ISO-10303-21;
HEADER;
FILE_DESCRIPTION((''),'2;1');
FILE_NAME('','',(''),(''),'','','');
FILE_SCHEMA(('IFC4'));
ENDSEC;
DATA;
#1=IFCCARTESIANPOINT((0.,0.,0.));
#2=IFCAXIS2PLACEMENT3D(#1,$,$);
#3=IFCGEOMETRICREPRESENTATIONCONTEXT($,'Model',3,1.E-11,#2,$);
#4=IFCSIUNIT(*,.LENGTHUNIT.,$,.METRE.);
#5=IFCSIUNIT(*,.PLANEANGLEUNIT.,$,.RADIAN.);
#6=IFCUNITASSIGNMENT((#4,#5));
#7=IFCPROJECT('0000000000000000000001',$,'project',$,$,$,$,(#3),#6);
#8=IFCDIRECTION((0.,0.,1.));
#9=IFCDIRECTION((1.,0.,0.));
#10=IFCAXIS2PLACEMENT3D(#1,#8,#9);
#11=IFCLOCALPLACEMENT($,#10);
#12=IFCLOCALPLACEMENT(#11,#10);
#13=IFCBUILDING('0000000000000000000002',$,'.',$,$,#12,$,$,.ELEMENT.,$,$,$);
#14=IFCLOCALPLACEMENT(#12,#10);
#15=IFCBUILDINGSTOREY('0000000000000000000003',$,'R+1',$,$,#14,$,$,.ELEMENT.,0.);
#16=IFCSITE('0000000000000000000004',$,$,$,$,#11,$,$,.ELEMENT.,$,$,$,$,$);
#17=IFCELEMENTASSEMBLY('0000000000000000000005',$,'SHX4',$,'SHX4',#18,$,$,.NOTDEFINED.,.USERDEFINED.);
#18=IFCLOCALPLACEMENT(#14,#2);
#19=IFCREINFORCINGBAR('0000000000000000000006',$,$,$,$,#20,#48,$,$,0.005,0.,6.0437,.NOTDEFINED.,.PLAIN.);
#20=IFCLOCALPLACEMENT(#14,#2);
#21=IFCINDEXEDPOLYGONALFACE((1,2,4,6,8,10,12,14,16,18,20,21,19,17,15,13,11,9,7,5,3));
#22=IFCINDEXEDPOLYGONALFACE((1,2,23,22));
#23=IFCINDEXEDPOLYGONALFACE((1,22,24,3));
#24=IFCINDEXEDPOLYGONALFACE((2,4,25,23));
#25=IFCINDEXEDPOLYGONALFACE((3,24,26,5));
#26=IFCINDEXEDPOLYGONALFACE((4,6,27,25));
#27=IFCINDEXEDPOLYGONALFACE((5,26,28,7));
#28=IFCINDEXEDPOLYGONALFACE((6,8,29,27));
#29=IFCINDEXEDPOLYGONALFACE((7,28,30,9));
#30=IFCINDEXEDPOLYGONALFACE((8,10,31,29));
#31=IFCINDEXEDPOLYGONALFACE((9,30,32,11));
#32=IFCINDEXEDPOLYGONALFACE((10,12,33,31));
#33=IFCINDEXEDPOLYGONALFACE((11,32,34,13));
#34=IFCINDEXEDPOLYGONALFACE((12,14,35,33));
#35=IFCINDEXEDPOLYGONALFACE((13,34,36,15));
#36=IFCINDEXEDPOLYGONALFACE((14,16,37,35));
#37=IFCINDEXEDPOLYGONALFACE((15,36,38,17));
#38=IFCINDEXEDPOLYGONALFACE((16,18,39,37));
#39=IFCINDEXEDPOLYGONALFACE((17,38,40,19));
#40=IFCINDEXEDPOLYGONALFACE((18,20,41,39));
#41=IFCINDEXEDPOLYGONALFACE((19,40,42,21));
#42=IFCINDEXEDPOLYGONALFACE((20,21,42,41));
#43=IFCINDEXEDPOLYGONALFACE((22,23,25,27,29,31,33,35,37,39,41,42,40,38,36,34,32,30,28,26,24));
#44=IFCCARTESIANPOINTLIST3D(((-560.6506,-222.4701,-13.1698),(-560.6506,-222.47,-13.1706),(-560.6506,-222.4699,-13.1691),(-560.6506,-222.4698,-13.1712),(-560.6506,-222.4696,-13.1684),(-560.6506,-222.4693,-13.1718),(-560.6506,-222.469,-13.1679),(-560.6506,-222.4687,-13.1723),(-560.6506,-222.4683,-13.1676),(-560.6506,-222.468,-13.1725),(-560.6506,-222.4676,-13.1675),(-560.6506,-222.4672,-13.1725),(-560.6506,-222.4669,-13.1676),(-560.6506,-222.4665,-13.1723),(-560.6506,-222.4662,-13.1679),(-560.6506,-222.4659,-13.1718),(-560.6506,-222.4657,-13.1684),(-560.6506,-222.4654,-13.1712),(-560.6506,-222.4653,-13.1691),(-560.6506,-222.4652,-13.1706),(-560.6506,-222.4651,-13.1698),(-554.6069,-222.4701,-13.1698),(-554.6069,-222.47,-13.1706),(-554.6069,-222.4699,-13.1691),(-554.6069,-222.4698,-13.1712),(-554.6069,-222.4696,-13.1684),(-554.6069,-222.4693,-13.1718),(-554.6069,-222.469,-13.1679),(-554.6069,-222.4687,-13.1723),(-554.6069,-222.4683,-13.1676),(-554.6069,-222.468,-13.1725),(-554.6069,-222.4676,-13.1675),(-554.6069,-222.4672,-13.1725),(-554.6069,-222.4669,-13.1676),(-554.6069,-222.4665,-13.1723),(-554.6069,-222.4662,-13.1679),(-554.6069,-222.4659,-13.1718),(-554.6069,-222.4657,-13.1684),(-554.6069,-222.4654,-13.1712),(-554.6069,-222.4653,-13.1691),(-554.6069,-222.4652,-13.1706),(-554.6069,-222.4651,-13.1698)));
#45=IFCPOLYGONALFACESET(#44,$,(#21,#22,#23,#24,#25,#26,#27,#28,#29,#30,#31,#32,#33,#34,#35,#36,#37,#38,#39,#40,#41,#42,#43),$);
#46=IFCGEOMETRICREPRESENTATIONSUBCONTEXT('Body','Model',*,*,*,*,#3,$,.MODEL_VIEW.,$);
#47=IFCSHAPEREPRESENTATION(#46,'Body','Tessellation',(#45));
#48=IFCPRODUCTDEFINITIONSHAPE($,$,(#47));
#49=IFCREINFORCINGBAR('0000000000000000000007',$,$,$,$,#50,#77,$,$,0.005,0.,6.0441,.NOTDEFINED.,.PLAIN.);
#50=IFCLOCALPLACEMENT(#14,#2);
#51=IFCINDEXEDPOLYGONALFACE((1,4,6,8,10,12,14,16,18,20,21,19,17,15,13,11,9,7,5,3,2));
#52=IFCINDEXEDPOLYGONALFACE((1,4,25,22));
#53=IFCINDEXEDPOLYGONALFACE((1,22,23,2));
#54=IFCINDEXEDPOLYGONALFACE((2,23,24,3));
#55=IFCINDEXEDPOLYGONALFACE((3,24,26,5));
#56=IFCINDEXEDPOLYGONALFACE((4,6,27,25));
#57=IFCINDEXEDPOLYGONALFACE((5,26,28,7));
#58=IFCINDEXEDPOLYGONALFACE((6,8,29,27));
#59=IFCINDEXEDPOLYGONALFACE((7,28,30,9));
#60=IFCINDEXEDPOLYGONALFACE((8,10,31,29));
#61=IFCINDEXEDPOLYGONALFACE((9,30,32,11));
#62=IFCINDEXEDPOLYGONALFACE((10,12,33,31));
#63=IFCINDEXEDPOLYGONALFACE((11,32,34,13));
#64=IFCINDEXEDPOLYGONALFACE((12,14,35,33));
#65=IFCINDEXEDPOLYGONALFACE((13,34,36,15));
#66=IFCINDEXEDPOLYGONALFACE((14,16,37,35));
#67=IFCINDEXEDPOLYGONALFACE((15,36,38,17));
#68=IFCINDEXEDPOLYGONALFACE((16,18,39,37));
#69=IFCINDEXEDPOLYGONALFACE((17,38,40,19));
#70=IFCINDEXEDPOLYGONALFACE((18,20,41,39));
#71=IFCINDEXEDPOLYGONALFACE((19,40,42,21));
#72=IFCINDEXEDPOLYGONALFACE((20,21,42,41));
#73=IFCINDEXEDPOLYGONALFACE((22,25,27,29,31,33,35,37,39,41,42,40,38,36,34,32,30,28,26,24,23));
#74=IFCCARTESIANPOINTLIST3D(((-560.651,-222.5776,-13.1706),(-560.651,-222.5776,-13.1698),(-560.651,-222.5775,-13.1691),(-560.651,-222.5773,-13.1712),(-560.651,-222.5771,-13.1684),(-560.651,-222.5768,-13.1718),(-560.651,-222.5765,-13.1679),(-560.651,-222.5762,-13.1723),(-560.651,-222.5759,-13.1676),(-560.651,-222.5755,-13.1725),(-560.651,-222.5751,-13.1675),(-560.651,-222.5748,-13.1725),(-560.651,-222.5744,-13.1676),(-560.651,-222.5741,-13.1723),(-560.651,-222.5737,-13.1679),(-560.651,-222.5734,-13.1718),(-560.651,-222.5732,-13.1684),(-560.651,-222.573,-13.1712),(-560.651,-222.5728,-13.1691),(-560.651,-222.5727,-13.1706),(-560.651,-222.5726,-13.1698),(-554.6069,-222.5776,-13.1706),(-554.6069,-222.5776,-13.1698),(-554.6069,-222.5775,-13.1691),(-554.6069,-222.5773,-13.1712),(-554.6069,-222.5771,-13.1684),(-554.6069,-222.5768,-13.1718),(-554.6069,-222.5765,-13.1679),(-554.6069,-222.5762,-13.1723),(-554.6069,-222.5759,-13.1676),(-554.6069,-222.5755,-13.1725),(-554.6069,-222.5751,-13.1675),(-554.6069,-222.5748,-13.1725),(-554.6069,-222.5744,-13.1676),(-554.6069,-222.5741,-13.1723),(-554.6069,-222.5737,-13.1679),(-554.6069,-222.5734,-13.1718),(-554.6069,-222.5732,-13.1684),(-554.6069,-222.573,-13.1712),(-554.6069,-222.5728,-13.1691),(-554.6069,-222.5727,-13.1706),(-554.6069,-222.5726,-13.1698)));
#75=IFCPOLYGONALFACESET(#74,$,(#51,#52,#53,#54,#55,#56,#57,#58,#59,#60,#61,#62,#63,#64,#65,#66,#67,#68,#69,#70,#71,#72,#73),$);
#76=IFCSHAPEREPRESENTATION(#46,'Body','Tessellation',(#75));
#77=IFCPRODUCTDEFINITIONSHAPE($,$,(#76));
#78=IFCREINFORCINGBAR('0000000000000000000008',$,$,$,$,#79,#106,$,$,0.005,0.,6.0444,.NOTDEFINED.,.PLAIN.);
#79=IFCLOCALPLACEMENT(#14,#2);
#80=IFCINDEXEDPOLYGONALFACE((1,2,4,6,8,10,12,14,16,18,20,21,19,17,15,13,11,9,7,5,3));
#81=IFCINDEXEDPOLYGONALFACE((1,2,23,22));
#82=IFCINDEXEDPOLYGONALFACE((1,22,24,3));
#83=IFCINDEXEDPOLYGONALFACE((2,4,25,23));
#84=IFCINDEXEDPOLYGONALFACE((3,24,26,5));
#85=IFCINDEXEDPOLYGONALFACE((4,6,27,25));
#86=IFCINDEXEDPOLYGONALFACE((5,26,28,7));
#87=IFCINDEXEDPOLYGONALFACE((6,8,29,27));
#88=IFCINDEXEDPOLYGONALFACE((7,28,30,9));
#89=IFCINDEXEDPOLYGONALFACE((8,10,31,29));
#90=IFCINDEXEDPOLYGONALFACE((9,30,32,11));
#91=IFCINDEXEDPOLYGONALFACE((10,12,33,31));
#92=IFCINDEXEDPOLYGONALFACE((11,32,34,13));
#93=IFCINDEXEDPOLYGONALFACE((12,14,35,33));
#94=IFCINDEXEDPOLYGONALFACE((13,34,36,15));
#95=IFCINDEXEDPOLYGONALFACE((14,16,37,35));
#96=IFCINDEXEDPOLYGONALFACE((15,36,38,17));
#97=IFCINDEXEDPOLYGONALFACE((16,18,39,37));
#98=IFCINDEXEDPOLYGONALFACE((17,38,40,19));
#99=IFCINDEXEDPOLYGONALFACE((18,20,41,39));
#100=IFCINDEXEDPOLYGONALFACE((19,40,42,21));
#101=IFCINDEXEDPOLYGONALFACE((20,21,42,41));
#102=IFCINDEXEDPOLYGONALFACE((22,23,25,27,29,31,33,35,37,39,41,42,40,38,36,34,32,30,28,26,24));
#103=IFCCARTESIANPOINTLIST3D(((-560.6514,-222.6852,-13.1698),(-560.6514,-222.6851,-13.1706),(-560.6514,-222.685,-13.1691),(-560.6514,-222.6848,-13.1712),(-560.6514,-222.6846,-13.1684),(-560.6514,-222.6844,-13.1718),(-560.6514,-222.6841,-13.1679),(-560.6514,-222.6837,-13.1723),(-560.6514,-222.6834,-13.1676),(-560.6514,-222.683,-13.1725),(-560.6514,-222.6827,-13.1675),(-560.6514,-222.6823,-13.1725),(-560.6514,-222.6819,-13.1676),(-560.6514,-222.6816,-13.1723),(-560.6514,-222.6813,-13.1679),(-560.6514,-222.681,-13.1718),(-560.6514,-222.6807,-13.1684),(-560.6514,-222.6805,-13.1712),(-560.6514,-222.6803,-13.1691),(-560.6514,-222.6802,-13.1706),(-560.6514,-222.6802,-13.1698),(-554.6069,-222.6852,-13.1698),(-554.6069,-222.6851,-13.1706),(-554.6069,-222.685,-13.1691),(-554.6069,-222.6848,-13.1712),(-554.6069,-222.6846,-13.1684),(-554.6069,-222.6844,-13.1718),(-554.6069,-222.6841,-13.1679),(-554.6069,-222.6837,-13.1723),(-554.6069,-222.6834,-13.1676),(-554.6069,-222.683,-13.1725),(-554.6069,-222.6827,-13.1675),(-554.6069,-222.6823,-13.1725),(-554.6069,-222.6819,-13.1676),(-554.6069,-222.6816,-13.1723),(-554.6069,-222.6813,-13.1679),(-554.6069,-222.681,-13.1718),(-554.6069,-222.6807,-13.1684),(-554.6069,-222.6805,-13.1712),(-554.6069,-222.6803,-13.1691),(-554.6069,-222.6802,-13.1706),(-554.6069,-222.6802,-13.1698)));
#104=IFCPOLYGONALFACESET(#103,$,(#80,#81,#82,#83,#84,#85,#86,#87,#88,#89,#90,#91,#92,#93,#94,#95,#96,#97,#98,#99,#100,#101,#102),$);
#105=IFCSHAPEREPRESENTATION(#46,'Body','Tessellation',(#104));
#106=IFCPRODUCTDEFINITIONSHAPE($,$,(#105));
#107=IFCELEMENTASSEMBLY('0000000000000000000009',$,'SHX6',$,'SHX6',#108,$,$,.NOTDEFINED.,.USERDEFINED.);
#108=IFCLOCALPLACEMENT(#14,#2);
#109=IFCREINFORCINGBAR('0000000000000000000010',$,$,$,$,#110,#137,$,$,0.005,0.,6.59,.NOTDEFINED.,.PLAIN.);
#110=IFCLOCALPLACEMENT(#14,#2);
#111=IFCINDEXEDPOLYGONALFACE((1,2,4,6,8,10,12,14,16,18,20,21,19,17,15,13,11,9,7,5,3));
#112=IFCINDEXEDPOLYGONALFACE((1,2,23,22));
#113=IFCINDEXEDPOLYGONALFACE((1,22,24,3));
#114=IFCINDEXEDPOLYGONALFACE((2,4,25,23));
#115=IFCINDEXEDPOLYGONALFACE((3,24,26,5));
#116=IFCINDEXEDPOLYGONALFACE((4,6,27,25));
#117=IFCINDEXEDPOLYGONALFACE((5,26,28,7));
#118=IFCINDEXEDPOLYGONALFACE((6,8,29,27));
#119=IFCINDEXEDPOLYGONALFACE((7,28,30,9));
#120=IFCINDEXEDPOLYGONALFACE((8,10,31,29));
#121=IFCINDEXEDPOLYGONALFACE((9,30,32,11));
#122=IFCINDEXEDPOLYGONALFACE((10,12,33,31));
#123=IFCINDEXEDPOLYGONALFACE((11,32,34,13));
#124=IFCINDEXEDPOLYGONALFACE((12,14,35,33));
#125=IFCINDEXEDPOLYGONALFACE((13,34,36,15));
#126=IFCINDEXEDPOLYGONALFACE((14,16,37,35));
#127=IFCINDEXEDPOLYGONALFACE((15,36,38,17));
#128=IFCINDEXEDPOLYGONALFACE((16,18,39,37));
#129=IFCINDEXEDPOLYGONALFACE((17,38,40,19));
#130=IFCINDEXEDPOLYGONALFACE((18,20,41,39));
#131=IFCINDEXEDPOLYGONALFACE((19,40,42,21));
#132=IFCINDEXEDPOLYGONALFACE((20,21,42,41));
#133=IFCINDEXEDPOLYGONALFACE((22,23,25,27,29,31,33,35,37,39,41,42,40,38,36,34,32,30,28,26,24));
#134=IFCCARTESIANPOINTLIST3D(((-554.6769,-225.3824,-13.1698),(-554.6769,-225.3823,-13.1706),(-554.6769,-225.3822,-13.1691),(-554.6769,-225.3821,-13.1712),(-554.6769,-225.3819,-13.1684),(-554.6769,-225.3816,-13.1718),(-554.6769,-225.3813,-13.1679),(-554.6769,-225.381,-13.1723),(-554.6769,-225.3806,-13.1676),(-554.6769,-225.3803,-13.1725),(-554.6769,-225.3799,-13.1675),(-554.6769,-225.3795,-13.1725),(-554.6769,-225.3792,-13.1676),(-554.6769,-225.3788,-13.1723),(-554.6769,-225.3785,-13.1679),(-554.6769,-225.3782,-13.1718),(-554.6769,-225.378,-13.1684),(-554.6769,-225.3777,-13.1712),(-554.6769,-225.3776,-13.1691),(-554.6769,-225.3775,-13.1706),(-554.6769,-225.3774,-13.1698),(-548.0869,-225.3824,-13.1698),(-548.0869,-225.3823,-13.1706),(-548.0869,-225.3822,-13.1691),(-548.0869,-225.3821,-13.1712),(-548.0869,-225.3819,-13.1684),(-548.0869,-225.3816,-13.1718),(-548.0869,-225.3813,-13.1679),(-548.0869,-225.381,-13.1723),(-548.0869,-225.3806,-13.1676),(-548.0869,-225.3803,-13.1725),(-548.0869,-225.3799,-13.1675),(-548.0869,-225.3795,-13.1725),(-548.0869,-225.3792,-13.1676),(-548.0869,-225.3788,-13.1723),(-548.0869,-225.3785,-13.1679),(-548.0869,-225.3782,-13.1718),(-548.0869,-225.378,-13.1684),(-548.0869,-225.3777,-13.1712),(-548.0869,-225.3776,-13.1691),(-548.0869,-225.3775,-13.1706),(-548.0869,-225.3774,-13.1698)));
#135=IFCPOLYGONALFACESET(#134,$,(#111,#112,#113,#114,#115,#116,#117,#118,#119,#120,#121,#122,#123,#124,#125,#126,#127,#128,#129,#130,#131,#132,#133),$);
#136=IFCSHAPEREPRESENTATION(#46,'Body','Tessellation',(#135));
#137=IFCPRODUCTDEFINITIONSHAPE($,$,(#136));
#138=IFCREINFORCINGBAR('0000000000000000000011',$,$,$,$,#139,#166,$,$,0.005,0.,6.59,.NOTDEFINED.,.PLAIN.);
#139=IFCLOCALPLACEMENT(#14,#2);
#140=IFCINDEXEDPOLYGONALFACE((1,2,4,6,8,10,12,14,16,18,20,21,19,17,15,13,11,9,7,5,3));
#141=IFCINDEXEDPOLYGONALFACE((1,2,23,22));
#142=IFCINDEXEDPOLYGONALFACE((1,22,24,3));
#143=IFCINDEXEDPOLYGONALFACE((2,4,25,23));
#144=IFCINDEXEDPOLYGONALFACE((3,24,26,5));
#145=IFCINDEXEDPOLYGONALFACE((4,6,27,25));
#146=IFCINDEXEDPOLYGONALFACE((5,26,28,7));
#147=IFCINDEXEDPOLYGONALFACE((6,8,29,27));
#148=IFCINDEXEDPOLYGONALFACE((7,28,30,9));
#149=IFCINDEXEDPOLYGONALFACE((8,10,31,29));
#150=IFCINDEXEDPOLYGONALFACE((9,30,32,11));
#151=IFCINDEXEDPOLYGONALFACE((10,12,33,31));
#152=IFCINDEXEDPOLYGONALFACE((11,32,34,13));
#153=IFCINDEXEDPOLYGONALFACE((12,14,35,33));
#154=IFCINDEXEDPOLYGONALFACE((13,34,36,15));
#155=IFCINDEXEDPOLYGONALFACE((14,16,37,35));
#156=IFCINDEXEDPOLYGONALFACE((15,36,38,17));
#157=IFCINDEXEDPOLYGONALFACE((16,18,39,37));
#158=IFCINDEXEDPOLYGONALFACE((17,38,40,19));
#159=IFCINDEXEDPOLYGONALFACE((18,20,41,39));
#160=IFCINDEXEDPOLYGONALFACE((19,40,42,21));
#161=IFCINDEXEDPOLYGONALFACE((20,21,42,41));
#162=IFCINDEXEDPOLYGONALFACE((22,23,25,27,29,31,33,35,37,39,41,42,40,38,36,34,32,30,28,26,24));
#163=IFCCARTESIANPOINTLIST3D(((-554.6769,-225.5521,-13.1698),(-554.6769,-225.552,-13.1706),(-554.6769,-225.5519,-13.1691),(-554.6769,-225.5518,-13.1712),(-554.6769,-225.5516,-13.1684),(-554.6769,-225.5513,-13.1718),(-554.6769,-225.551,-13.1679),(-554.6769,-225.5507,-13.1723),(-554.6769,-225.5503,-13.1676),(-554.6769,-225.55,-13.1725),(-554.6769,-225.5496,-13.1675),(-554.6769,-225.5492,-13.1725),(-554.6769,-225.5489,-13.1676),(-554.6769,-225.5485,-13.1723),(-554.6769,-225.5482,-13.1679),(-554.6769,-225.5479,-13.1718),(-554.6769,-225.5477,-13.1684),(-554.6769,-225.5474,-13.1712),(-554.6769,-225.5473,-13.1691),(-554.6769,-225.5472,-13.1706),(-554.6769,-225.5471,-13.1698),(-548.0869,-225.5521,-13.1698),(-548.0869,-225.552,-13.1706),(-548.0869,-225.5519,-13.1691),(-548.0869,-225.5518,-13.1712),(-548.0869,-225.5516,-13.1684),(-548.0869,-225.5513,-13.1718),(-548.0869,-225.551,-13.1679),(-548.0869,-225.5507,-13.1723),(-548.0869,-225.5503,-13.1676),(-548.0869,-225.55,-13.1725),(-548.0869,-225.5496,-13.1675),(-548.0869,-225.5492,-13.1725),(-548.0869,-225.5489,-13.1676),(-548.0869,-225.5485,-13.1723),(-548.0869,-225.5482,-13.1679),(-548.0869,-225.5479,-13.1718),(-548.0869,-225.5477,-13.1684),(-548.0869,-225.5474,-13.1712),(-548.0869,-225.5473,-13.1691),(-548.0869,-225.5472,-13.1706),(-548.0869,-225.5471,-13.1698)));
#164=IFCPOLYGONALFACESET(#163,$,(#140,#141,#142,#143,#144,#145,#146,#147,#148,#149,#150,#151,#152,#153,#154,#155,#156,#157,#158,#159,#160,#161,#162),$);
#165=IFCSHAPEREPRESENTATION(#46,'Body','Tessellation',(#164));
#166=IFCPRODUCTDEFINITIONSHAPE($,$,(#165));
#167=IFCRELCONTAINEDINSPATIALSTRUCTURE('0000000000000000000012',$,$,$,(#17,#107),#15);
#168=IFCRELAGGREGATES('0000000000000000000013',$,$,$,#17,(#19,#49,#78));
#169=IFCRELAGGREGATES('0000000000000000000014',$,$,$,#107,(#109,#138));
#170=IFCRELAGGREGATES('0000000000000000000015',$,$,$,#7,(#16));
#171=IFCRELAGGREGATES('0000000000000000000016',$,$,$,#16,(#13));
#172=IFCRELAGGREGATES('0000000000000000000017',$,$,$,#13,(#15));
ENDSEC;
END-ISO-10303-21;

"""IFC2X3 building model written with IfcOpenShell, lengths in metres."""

from ifc_helpers import new_model, entity, si_unit, origin, origin_with_axes, place, context, subcontext, project, spatial, shape, element, aggregate, save


model = new_model("IFC2X3")

# Units and contexts
model_context = context("Model", 3, precision=1e-11, world=origin())
body_context = subcontext(model_context, "Body", "Model", "MODEL_VIEW")
ifc_project = project(units=[si_unit("LENGTHUNIT", "METRE"), si_unit("PLANEANGLEUNIT", "RADIAN")], contexts=[model_context])

# Site, building, storey
site_placement = place(None, origin_with_axes())
site = spatial("IfcSite", under=ifc_project, at=site_placement, CompositionType="ELEMENT")
building_placement = place(site_placement, origin_with_axes())
building = spatial("IfcBuilding", under=site, at=building_placement, Name=".", CompositionType="ELEMENT")
storey_placement = place(building_placement, origin_with_axes())
storey = spatial("IfcBuildingStorey", under=building, at=storey_placement, Name="R+1", CompositionType="ELEMENT", Elevation=0.0)

# Element assemblies, reinforcing bars
assembly_1_placement = place(storey_placement, origin_with_axes())
assembly_1 = element("IfcElementAssembly", 1, at=assembly_1_placement, inside=storey, Name="SHX4", ObjectType="SHX4", AssemblyPlace="NOTDEFINED", PredefinedType="USERDEFINED")
reinforcing_bar_1_placement = place(assembly_1_placement, origin_with_axes())
reinforcing_bar_1 = element("IfcReinforcingBar", 2, at=reinforcing_bar_1_placement, BarLength=6.0437, BarRole="NOTDEFINED", BarSurface="PLAIN", CrossSectionArea=0.0, NominalDiameter=0.005, shapes=[
    shape(body_context, "Body", "AdvancedSweptSolid", [entity("IfcSweptDiskSolid", entity("IfcPolyline", [entity("IfcCartesianPoint", [554.6069, 222.4676, 13.17]), entity("IfcCartesianPoint", [560.6506, 222.4676, 13.17])]), 0.0025, None, 0.0, 6.0437)]),
    shape(body_context, "Body", "AdvancedSweptSolid", [entity("IfcSweptDiskSolid", entity("IfcPolyline", [entity("IfcCartesianPoint", [554.6069, 222.4676, 13.17]), entity("IfcCartesianPoint", [560.6506, 222.4676, 13.17])]), 0.0025, None, 0.0, 6.0437)]),
])
reinforcing_bar_2_placement = place(assembly_1_placement, origin_with_axes())
reinforcing_bar_2 = element("IfcReinforcingBar", 3, at=reinforcing_bar_2_placement, BarLength=6.0441, BarRole="NOTDEFINED", BarSurface="PLAIN", CrossSectionArea=0.0, NominalDiameter=0.005, shapes=[
    shape(body_context, "Body", "AdvancedSweptSolid", [entity("IfcSweptDiskSolid", entity("IfcPolyline", [entity("IfcCartesianPoint", [554.6069, 222.5751, 13.17]), entity("IfcCartesianPoint", [560.651, 222.5751, 13.17])]), 0.0025, None, 0.0, 6.0441)]),
    shape(body_context, "Body", "AdvancedSweptSolid", [entity("IfcSweptDiskSolid", entity("IfcPolyline", [entity("IfcCartesianPoint", [554.6069, 222.5751, 13.17]), entity("IfcCartesianPoint", [560.651, 222.5751, 13.17])]), 0.0025, None, 0.0, 6.0441)]),
])
reinforcing_bar_3_placement = place(assembly_1_placement, origin_with_axes())
reinforcing_bar_3 = element("IfcReinforcingBar", 4, at=reinforcing_bar_3_placement, BarLength=6.0444, BarRole="NOTDEFINED", BarSurface="PLAIN", CrossSectionArea=0.0, NominalDiameter=0.005, shapes=[
    shape(body_context, "Body", "AdvancedSweptSolid", [entity("IfcSweptDiskSolid", entity("IfcPolyline", [entity("IfcCartesianPoint", [554.6069, 222.6827, 13.17]), entity("IfcCartesianPoint", [560.6514, 222.6827, 13.17])]), 0.0025, None, 0.0, 6.0444)]),
    shape(body_context, "Body", "AdvancedSweptSolid", [entity("IfcSweptDiskSolid", entity("IfcPolyline", [entity("IfcCartesianPoint", [554.6069, 222.6827, 13.17]), entity("IfcCartesianPoint", [560.6514, 222.6827, 13.17])]), 0.0025, None, 0.0, 6.0444)]),
])
aggregate(assembly_1, [reinforcing_bar_1, reinforcing_bar_2, reinforcing_bar_3])
assembly_2_placement = place(storey_placement, origin_with_axes())
assembly_2 = element("IfcElementAssembly", 5, at=assembly_2_placement, inside=storey, Name="SHX6", ObjectType="SHX6", AssemblyPlace="NOTDEFINED", PredefinedType="USERDEFINED")
reinforcing_bar_4_placement = place(assembly_2_placement, origin_with_axes())
reinforcing_bar_4 = element("IfcReinforcingBar", 6, at=reinforcing_bar_4_placement, BarLength=6.59, BarRole="NOTDEFINED", BarSurface="PLAIN", CrossSectionArea=0.0, NominalDiameter=0.005, shapes=[
    shape(body_context, "Body", "AdvancedSweptSolid", [entity("IfcSweptDiskSolid", entity("IfcPolyline", [entity("IfcCartesianPoint", [548.0869, 225.3799, 13.17]), entity("IfcCartesianPoint", [554.6769, 225.3799, 13.17])]), 0.0025, None, 0.0, 6.59)]),
    shape(body_context, "Body", "AdvancedSweptSolid", [entity("IfcSweptDiskSolid", entity("IfcPolyline", [entity("IfcCartesianPoint", [548.0869, 225.3799, 13.17]), entity("IfcCartesianPoint", [554.6769, 225.3799, 13.17])]), 0.0025, None, 0.0, 6.59)]),
])
reinforcing_bar_5_placement = place(assembly_2_placement, origin_with_axes())
reinforcing_bar_5 = element("IfcReinforcingBar", 7, at=reinforcing_bar_5_placement, BarLength=6.59, BarRole="NOTDEFINED", BarSurface="PLAIN", CrossSectionArea=0.0, NominalDiameter=0.005, shapes=[
    shape(body_context, "Body", "AdvancedSweptSolid", [entity("IfcSweptDiskSolid", entity("IfcPolyline", [entity("IfcCartesianPoint", [548.0869, 225.5496, 13.17]), entity("IfcCartesianPoint", [554.6769, 225.5496, 13.17])]), 0.0025, None, 0.0, 6.59)]),
    shape(body_context, "Body", "AdvancedSweptSolid", [entity("IfcSweptDiskSolid", entity("IfcPolyline", [entity("IfcCartesianPoint", [548.0869, 225.5496, 13.17]), entity("IfcCartesianPoint", [554.6769, 225.5496, 13.17])]), 0.0025, None, 0.0, 6.59)]),
])
aggregate(assembly_2, [reinforcing_bar_4, reinforcing_bar_5])

save(model, "model.ifc")
